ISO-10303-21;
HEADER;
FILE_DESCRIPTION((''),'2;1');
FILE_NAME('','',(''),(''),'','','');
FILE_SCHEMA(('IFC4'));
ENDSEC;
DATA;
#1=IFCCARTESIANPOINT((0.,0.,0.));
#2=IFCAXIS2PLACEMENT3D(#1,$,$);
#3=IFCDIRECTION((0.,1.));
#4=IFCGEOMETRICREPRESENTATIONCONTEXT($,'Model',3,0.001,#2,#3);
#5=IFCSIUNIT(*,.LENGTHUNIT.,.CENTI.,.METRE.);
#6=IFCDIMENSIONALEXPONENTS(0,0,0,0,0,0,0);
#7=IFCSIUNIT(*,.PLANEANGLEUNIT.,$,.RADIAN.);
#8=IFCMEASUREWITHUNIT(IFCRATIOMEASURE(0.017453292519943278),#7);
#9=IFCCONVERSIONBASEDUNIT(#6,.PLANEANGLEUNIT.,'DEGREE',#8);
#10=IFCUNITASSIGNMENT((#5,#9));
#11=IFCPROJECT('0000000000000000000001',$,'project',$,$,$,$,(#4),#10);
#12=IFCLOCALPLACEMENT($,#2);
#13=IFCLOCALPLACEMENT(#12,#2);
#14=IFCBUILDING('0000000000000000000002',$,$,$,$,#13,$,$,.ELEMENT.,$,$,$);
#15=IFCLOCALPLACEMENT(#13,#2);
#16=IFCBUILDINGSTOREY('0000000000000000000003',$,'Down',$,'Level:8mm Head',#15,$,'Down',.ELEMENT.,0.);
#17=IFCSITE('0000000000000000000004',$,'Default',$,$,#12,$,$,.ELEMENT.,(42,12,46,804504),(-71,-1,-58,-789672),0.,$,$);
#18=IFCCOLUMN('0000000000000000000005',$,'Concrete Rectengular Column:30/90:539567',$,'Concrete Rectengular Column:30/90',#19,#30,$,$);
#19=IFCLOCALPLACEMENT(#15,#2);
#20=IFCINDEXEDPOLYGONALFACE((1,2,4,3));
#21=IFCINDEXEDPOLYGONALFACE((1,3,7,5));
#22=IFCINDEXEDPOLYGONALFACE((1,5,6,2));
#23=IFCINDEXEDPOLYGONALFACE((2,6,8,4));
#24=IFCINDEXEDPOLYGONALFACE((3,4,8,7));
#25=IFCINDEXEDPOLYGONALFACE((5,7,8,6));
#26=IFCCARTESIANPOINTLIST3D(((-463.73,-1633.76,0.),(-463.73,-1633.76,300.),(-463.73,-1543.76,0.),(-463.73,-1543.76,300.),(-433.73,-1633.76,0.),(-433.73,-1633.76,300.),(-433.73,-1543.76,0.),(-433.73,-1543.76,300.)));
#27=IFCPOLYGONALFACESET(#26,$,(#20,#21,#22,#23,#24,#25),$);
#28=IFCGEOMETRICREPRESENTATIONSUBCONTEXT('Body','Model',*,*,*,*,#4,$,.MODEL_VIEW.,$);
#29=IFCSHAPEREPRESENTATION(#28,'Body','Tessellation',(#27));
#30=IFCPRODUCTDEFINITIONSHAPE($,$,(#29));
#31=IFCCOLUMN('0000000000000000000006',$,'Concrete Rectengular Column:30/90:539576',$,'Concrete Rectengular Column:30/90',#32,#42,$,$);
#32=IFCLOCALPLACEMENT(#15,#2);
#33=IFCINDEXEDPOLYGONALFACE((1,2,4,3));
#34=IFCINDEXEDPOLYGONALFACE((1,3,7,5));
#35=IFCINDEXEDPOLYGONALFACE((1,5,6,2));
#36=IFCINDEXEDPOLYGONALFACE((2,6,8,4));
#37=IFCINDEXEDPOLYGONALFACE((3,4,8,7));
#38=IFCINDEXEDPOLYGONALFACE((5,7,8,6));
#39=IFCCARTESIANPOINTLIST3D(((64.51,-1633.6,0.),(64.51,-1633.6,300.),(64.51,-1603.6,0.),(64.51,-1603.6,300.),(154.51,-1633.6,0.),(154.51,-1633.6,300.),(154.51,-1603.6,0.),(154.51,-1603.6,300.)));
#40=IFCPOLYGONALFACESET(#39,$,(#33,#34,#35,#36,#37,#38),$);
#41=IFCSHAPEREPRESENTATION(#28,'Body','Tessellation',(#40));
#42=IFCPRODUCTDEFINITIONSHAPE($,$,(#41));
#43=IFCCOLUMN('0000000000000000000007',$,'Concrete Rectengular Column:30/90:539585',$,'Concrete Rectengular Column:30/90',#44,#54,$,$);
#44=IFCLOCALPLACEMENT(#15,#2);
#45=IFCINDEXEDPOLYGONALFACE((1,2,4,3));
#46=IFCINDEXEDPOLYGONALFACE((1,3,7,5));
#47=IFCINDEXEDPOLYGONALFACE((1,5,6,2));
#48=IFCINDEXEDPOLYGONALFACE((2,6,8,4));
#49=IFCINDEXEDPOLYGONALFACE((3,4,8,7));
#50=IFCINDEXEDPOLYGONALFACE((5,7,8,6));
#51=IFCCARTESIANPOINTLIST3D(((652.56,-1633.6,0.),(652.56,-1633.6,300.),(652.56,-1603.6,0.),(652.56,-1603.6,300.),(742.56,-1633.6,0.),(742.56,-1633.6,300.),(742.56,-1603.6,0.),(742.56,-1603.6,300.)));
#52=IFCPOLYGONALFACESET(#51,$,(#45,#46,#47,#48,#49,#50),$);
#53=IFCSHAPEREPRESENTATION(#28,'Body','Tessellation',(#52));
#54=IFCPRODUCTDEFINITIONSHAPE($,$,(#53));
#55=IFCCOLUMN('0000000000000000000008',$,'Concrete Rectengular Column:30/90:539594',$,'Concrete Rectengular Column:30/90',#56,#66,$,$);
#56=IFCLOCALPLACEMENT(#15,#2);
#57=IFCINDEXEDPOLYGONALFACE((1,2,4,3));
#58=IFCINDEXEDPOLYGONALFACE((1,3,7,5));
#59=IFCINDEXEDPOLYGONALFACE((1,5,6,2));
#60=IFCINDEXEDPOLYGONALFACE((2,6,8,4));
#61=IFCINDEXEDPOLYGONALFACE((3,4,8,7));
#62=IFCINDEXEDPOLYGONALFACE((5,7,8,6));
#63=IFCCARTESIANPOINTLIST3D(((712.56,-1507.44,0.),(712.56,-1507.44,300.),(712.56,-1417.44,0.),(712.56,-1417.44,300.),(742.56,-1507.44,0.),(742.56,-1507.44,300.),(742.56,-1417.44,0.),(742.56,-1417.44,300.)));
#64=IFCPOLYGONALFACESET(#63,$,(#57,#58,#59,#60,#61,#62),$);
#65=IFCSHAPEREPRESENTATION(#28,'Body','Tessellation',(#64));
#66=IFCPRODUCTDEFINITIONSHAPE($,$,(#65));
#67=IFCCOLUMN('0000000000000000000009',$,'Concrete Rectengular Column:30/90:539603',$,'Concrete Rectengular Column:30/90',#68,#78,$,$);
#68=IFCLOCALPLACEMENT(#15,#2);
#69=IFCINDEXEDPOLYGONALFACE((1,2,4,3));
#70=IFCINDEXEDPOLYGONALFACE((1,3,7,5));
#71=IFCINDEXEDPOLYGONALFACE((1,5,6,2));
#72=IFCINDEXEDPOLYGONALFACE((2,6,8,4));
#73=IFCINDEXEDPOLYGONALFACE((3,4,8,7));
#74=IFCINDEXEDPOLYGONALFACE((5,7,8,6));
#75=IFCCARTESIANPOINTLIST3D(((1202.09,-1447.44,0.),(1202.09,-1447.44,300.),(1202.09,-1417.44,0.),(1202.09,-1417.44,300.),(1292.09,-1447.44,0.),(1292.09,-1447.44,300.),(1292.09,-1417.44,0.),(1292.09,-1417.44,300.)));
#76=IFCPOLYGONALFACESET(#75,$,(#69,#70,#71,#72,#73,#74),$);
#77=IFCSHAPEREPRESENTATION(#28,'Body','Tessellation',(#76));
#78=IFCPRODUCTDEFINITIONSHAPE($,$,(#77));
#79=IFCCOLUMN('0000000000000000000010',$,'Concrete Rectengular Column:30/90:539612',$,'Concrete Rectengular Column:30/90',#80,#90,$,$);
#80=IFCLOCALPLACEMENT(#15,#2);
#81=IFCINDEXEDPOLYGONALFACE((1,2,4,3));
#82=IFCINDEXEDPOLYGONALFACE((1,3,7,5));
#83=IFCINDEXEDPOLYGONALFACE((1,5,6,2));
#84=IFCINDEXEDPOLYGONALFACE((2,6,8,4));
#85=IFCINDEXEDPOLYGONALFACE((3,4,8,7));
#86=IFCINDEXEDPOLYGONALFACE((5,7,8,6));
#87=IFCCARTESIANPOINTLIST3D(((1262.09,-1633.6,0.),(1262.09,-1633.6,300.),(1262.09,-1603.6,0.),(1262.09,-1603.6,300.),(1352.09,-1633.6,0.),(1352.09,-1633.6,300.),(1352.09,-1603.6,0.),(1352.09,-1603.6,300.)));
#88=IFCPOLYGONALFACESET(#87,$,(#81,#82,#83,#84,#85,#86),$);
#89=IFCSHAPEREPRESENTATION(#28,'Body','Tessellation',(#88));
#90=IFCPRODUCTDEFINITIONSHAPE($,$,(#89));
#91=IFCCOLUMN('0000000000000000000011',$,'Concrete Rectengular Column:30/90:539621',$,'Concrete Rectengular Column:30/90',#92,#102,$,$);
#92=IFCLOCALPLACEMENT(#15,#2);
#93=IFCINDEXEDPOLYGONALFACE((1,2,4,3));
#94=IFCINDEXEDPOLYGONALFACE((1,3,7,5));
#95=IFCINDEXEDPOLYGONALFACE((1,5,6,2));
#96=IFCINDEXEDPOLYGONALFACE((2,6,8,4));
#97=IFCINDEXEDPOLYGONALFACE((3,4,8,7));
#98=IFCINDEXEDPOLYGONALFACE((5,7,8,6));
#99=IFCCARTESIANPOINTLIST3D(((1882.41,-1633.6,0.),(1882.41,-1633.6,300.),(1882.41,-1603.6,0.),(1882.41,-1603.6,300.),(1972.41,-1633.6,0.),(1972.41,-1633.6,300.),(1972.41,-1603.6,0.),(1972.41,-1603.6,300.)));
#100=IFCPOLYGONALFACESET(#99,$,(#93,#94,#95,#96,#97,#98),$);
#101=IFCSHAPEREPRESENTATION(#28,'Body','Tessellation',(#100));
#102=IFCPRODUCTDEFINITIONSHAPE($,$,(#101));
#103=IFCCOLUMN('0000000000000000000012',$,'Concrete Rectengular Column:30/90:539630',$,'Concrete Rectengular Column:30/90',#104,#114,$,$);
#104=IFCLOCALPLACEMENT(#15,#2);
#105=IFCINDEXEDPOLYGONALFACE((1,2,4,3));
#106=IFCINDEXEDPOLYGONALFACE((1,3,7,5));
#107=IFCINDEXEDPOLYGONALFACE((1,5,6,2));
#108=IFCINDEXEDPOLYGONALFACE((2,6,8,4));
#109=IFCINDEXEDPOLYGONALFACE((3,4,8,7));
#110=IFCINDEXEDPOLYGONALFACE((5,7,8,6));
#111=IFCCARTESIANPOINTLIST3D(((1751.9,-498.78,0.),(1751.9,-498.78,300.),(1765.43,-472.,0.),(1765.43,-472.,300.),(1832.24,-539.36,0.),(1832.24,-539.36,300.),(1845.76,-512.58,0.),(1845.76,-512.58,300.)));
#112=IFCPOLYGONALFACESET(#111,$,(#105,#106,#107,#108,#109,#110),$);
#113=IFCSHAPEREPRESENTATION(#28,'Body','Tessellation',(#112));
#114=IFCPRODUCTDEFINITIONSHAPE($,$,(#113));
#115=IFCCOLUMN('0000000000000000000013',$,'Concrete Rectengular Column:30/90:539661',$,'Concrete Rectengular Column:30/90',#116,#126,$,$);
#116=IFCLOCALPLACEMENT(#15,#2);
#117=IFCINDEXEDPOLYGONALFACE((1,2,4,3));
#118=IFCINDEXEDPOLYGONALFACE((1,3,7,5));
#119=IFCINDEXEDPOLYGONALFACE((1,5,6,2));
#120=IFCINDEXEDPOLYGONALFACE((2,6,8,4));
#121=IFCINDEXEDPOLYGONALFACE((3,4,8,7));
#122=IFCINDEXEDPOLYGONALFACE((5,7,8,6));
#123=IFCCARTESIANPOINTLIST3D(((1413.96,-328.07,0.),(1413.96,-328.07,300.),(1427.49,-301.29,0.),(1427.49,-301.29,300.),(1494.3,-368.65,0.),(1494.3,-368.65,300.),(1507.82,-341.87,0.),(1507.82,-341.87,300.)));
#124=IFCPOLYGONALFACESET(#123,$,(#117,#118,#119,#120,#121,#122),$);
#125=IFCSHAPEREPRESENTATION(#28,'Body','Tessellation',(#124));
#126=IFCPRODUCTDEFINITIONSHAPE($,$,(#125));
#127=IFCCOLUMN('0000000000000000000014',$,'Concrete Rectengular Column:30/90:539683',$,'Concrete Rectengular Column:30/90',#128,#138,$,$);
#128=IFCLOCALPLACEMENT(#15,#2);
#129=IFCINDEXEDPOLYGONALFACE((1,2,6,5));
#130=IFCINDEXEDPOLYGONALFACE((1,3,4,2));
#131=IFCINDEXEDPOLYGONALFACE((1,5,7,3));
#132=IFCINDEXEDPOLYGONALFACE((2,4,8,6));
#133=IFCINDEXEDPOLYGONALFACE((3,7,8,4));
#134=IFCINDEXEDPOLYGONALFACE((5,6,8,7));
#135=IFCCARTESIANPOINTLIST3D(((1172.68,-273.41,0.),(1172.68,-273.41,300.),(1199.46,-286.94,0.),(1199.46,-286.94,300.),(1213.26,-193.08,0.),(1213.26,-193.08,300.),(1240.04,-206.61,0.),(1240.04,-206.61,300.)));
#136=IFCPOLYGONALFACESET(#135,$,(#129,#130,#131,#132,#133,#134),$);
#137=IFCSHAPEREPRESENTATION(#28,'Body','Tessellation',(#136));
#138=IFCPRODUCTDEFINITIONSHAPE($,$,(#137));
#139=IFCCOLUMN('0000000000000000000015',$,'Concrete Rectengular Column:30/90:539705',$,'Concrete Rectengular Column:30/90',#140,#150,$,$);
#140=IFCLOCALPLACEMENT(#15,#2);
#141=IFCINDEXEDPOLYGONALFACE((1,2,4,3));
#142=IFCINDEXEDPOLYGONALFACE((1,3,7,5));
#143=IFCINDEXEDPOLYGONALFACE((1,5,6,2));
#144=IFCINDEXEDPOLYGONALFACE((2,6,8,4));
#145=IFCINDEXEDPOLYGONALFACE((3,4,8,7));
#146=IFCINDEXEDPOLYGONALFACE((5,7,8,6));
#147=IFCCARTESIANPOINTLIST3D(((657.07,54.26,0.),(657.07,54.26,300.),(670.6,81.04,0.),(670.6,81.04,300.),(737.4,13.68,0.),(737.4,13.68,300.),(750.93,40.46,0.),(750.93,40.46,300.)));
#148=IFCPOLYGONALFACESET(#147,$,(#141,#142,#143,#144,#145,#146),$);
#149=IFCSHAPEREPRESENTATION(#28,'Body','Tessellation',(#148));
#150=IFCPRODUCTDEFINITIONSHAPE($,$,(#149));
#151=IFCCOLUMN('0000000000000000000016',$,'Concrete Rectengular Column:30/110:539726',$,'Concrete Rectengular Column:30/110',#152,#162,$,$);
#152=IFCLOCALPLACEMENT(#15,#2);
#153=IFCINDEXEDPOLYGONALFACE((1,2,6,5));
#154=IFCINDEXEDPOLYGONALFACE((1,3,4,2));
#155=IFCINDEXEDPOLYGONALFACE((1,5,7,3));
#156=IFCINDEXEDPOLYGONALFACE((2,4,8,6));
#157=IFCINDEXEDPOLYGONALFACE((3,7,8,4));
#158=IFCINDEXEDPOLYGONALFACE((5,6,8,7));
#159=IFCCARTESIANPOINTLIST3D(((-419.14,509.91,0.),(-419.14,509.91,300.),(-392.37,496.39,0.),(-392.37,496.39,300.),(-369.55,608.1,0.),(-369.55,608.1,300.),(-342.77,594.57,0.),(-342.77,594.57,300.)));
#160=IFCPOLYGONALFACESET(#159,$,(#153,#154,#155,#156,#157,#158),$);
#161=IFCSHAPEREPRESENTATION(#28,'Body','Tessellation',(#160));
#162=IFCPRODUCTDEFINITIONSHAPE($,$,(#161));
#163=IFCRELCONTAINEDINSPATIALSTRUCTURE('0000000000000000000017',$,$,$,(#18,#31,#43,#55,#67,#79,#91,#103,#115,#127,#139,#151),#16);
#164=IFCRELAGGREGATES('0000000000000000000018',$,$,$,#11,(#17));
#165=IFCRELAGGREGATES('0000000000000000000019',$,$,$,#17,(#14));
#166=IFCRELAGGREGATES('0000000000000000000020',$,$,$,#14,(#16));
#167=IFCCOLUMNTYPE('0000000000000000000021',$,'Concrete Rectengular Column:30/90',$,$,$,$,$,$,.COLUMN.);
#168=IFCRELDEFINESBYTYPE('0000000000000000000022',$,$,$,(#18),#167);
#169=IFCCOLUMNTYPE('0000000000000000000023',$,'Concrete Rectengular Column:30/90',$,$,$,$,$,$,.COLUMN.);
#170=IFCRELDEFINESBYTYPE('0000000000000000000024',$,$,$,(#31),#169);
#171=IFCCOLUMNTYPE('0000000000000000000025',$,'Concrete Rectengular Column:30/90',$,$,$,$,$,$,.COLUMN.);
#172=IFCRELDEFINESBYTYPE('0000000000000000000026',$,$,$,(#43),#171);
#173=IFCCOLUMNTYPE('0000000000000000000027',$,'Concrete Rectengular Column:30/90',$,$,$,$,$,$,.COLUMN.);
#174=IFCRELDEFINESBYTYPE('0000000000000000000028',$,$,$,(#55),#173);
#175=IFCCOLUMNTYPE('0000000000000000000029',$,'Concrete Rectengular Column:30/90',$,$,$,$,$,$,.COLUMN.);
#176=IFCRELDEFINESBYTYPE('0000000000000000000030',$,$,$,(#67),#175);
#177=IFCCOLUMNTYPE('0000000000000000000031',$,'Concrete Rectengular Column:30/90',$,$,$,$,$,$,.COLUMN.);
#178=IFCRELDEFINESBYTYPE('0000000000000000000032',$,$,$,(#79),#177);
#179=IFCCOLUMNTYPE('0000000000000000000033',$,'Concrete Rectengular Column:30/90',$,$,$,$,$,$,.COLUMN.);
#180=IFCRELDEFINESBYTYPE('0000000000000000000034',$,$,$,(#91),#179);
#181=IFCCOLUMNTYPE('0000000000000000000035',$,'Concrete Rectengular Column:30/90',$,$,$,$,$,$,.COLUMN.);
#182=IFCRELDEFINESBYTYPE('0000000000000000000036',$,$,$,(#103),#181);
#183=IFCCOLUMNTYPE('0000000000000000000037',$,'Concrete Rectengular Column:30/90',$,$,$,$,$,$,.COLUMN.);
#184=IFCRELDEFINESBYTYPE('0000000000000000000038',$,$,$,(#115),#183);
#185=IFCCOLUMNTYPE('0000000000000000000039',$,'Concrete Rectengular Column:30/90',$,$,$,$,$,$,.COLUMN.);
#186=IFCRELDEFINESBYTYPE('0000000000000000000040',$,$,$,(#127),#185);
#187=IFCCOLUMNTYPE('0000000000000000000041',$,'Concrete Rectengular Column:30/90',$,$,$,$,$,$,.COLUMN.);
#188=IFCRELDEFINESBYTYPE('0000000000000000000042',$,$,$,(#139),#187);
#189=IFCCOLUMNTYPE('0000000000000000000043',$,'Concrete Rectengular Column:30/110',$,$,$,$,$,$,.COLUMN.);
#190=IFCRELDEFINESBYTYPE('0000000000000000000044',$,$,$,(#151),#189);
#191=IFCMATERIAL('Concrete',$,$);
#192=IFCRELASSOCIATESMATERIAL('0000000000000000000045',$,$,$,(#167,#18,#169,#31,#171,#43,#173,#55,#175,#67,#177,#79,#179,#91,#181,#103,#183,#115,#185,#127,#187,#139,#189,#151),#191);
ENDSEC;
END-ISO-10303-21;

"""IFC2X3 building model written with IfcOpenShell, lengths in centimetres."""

from ifc_helpers import new_model, entity, si_unit, converted_unit, direction, frame, frame_2d, origin, origin_2d_with_axis, place, context, subcontext, project, spatial, rectangle, extrude, source, transform, mapped, material, type_object, type_shapes, element, save


model = new_model("IFC2X3")

# Units and contexts
model_context = context("Model", 3, precision=0.001, world=origin(), true_north=direction((0.0, 1.0)))
body_context = subcontext(model_context, "Body", "Model", "MODEL_VIEW")
ifc_project = project(units=[si_unit("LENGTHUNIT", "METRE", prefix="CENTI"), converted_unit("PLANEANGLEUNIT", "DEGREE", entity("IfcRatioMeasure", 0.017453292519943278), si_unit("PLANEANGLEUNIT", "RADIAN"), dimensions=[0, 0, 0, 0, 0, 0, 0])], contexts=[model_context])

# Site, building, storey
site_placement = place(None, origin())
site = spatial("IfcSite", under=ifc_project, at=site_placement, Name="Default", CompositionType="ELEMENT", RefLatitude=(42, 12, 46, 804504), RefLongitude=(-71, -1, -58, -789672), RefElevation=0.0)
building_placement = place(site_placement, origin())
building = spatial("IfcBuilding", under=site, at=building_placement, CompositionType="ELEMENT")
storey_placement = place(building_placement, origin())
storey = spatial("IfcBuildingStorey", under=building, at=storey_placement, Name="Down", ObjectType="Level:8mm Head", LongName="Down", CompositionType="ELEMENT", Elevation=0.0)

# Columns
ifc_material = material(Name="Concrete")
column_type_1 = type_object("IfcColumnType", Name="Concrete Rectengular Column:30/90", PredefinedType="COLUMN", material=ifc_material)
shared_shape_1 = source(origin(), body_context, "Body", "SweptSolid", [
    extrude(rectangle(XDim=90.0, YDim=30.0, at=origin_2d_with_axis()), frame((-448.73, -1588.76, 0.0), z_axis=(0.0, 0.0, 1.0), x_axis=(0.0, -1.0, 0.0)), (0.0, 0.0, 1.0), 300.0),
])
type_shapes(column_type_1, [shared_shape_1])
column_1_placement = place(storey_placement, origin())
element("IfcColumn", 1, at=column_1_placement, inside=storey, type_object=column_type_1, material=ifc_material, Name="Concrete Rectengular Column:30/90:539567", ObjectType="Concrete Rectengular Column:30/90", context=body_context, shape_type="MappedRepresentation", body=[
    mapped(shared_shape_1, transform((0.0, 0.0, 0.0), scale=1.0)),
])
column_type_2 = type_object("IfcColumnType", Name="Concrete Rectengular Column:30/90", PredefinedType="COLUMN", material=ifc_material)
shared_shape_2 = source(origin(), body_context, "Body", "SweptSolid", [
    extrude(rectangle(XDim=30.0, YDim=90.0, at=frame_2d((0.0, 0.0), x_axis=(1.0, 0.0))), frame((109.51, -1618.6, 0.0), z_axis=(0.0, 0.0, 1.0), x_axis=(0.0, -1.0, 0.0)), (0.0, 0.0, 1.0), 300.0),
])
type_shapes(column_type_2, [shared_shape_2])
column_2_placement = place(storey_placement, origin())
element("IfcColumn", 2, at=column_2_placement, inside=storey, type_object=column_type_2, material=ifc_material, Name="Concrete Rectengular Column:30/90:539576", ObjectType="Concrete Rectengular Column:30/90", context=body_context, shape_type="MappedRepresentation", body=[
    mapped(shared_shape_2, transform((0.0, 0.0, 0.0), scale=1.0)),
])
column_type_3 = type_object("IfcColumnType", Name="Concrete Rectengular Column:30/90", PredefinedType="COLUMN", material=ifc_material)
shared_shape_3 = source(origin(), body_context, "Body", "SweptSolid", [
    extrude(rectangle(XDim=30.0, YDim=90.0, at=origin_2d_with_axis()), frame((697.56, -1618.6, 0.0), z_axis=(0.0, 0.0, 1.0), x_axis=(0.0, -1.0, 0.0)), (0.0, 0.0, 1.0), 300.0),
])
type_shapes(column_type_3, [shared_shape_3])
column_3_placement = place(storey_placement, origin())
element("IfcColumn", 3, at=column_3_placement, inside=storey, type_object=column_type_3, material=ifc_material, Name="Concrete Rectengular Column:30/90:539585", ObjectType="Concrete Rectengular Column:30/90", context=body_context, shape_type="MappedRepresentation", body=[
    mapped(shared_shape_3, transform((0.0, 0.0, 0.0), scale=1.0)),
])
column_type_4 = type_object("IfcColumnType", Name="Concrete Rectengular Column:30/90", PredefinedType="COLUMN", material=ifc_material)
shared_shape_4 = source(origin(), body_context, "Body", "SweptSolid", [
    extrude(rectangle(XDim=90.0, YDim=30.0, at=frame_2d((0.0, 0.0), x_axis=(1.0, 0.0))), frame((727.56, -1462.44, 0.0), z_axis=(0.0, 0.0, 1.0), x_axis=(0.0, -1.0, 0.0)), (0.0, 0.0, 1.0), 300.0),
])
type_shapes(column_type_4, [shared_shape_4])
column_4_placement = place(storey_placement, origin())
element("IfcColumn", 4, at=column_4_placement, inside=storey, type_object=column_type_4, material=ifc_material, Name="Concrete Rectengular Column:30/90:539594", ObjectType="Concrete Rectengular Column:30/90", context=body_context, shape_type="MappedRepresentation", body=[
    mapped(shared_shape_4, transform((0.0, 0.0, 0.0), scale=1.0)),
])
column_type_5 = type_object("IfcColumnType", Name="Concrete Rectengular Column:30/90", PredefinedType="COLUMN", material=ifc_material)
shared_shape_5 = source(origin(), body_context, "Body", "SweptSolid", [
    extrude(rectangle(XDim=30.0, YDim=90.0, at=frame_2d((0.0, 0.0), x_axis=(1.0, 0.0))), frame((1247.09, -1432.44, 0.0), z_axis=(0.0, 0.0, 1.0), x_axis=(0.0, -1.0, 0.0)), (0.0, 0.0, 1.0), 300.0),
])
type_shapes(column_type_5, [shared_shape_5])
column_5_placement = place(storey_placement, origin())
element("IfcColumn", 5, at=column_5_placement, inside=storey, type_object=column_type_5, material=ifc_material, Name="Concrete Rectengular Column:30/90:539603", ObjectType="Concrete Rectengular Column:30/90", context=body_context, shape_type="MappedRepresentation", body=[
    mapped(shared_shape_5, transform((0.0, 0.0, 0.0), scale=1.0)),
])
column_type_6 = type_object("IfcColumnType", Name="Concrete Rectengular Column:30/90", PredefinedType="COLUMN", material=ifc_material)
shared_shape_6 = source(origin(), body_context, "Body", "SweptSolid", [
    extrude(rectangle(XDim=30.0, YDim=90.0, at=frame_2d((0.0, 0.0), x_axis=(1.0, 0.0))), frame((1307.09, -1618.6, 0.0), z_axis=(0.0, 0.0, 1.0), x_axis=(0.0, -1.0, 0.0)), (0.0, 0.0, 1.0), 300.0),
])
type_shapes(column_type_6, [shared_shape_6])
column_6_placement = place(storey_placement, origin())
element("IfcColumn", 6, at=column_6_placement, inside=storey, type_object=column_type_6, material=ifc_material, Name="Concrete Rectengular Column:30/90:539612", ObjectType="Concrete Rectengular Column:30/90", context=body_context, shape_type="MappedRepresentation", body=[
    mapped(shared_shape_6, transform((0.0, 0.0, 0.0), scale=1.0)),
])
column_type_7 = type_object("IfcColumnType", Name="Concrete Rectengular Column:30/90", PredefinedType="COLUMN", material=ifc_material)
shared_shape_7 = source(origin(), body_context, "Body", "SweptSolid", [
    extrude(rectangle(XDim=30.0, YDim=90.0, at=frame_2d((0.0, 0.0), x_axis=(1.0, 0.0))), frame((1927.41, -1618.6, 0.0), z_axis=(0.0, 0.0, 1.0), x_axis=(0.0, -1.0, 0.0)), (0.0, 0.0, 1.0), 300.0),
])
type_shapes(column_type_7, [shared_shape_7])
column_7_placement = place(storey_placement, origin())
element("IfcColumn", 7, at=column_7_placement, inside=storey, type_object=column_type_7, material=ifc_material, Name="Concrete Rectengular Column:30/90:539621", ObjectType="Concrete Rectengular Column:30/90", context=body_context, shape_type="MappedRepresentation", body=[
    mapped(shared_shape_7, transform((0.0, 0.0, 0.0), scale=1.0)),
])
column_type_8 = type_object("IfcColumnType", Name="Concrete Rectengular Column:30/90", PredefinedType="COLUMN", material=ifc_material)
shared_shape_8 = source(origin(), body_context, "Body", "SweptSolid", [
    extrude(rectangle(XDim=90.0, YDim=30.0, at=frame_2d((0.0, 0.0), x_axis=(1.0, 0.0))), frame((1798.83, -505.68, 0.0), z_axis=(0.0, 0.0, 1.0), x_axis=(-0.892587, 0.450875, 0.0)), (0.0, 0.0, 1.0), 300.0),
])
type_shapes(column_type_8, [shared_shape_8])
column_8_placement = place(storey_placement, origin())
element("IfcColumn", 8, at=column_8_placement, inside=storey, type_object=column_type_8, material=ifc_material, Name="Concrete Rectengular Column:30/90:539630", ObjectType="Concrete Rectengular Column:30/90", context=body_context, shape_type="MappedRepresentation", body=[
    mapped(shared_shape_8, transform((0.0, 0.0, 0.0), scale=1.0)),
])
column_type_9 = type_object("IfcColumnType", Name="Concrete Rectengular Column:30/90", PredefinedType="COLUMN", material=ifc_material)
shared_shape_9 = source(origin(), body_context, "Body", "SweptSolid", [
    extrude(rectangle(XDim=90.0, YDim=30.0, at=origin_2d_with_axis()), frame((1460.89, -334.97, 0.0), z_axis=(0.0, 0.0, 1.0), x_axis=(-0.892587, 0.450875, 0.0)), (0.0, 0.0, 1.0), 300.0),
])
type_shapes(column_type_9, [shared_shape_9])
column_9_placement = place(storey_placement, origin())
element("IfcColumn", 9, at=column_9_placement, inside=storey, type_object=column_type_9, material=ifc_material, Name="Concrete Rectengular Column:30/90:539661", ObjectType="Concrete Rectengular Column:30/90", context=body_context, shape_type="MappedRepresentation", body=[
    mapped(shared_shape_9, transform((0.0, 0.0, 0.0), scale=1.0)),
])
column_type_10 = type_object("IfcColumnType", Name="Concrete Rectengular Column:30/90", PredefinedType="COLUMN", material=ifc_material)
shared_shape_10 = source(origin(), body_context, "Body", "SweptSolid", [
    extrude(rectangle(XDim=30.0, YDim=90.0, at=origin_2d_with_axis()), frame((1206.36, -240.01, 0.0), z_axis=(0.0, 0.0, 1.0), x_axis=(-0.892587, 0.450875, 0.0)), (0.0, 0.0, 1.0), 300.0),
])
type_shapes(column_type_10, [shared_shape_10])
column_10_placement = place(storey_placement, origin())
element("IfcColumn", 10, at=column_10_placement, inside=storey, type_object=column_type_10, material=ifc_material, Name="Concrete Rectengular Column:30/90:539683", ObjectType="Concrete Rectengular Column:30/90", context=body_context, shape_type="MappedRepresentation", body=[
    mapped(shared_shape_10, transform((0.0, 0.0, 0.0), scale=1.0)),
])
column_type_11 = type_object("IfcColumnType", Name="Concrete Rectengular Column:30/90", PredefinedType="COLUMN", material=ifc_material)
shared_shape_11 = source(origin(), body_context, "Body", "SweptSolid", [
    extrude(rectangle(XDim=90.0, YDim=30.0, at=origin_2d_with_axis()), frame((704.0, 47.36, 0.0), z_axis=(0.0, 0.0, 1.0), x_axis=(-0.892587, 0.450875, 0.0)), (0.0, 0.0, 1.0), 300.0),
])
type_shapes(column_type_11, [shared_shape_11])
column_11_placement = place(storey_placement, origin())
element("IfcColumn", 11, at=column_11_placement, inside=storey, type_object=column_type_11, material=ifc_material, Name="Concrete Rectengular Column:30/90:539705", ObjectType="Concrete Rectengular Column:30/90", context=body_context, shape_type="MappedRepresentation", body=[
    mapped(shared_shape_11, transform((0.0, 0.0, 0.0), scale=1.0)),
])
column_type_12 = type_object("IfcColumnType", Name="Concrete Rectengular Column:30/110", PredefinedType="COLUMN", material=ifc_material)
shared_shape_12 = source(origin(), body_context, "Body", "SweptSolid", [
    extrude(rectangle(XDim=30.0, YDim=110.0, at=frame_2d((0.0, 0.0), x_axis=(1.0, 0.0))), frame((-380.96, 552.24, 0.0), z_axis=(0.0, 0.0, 1.0), x_axis=(-0.892587, 0.450875, 0.0)), (0.0, 0.0, 1.0), 300.0),
])
type_shapes(column_type_12, [shared_shape_12])
column_12_placement = place(storey_placement, origin())
element("IfcColumn", 12, at=column_12_placement, inside=storey, type_object=column_type_12, material=ifc_material, Name="Concrete Rectengular Column:30/110:539726", ObjectType="Concrete Rectengular Column:30/110", context=body_context, shape_type="MappedRepresentation", body=[
    mapped(shared_shape_12, transform((0.0, 0.0, 0.0), scale=1.0)),
])

save(model, "model.ifc")
